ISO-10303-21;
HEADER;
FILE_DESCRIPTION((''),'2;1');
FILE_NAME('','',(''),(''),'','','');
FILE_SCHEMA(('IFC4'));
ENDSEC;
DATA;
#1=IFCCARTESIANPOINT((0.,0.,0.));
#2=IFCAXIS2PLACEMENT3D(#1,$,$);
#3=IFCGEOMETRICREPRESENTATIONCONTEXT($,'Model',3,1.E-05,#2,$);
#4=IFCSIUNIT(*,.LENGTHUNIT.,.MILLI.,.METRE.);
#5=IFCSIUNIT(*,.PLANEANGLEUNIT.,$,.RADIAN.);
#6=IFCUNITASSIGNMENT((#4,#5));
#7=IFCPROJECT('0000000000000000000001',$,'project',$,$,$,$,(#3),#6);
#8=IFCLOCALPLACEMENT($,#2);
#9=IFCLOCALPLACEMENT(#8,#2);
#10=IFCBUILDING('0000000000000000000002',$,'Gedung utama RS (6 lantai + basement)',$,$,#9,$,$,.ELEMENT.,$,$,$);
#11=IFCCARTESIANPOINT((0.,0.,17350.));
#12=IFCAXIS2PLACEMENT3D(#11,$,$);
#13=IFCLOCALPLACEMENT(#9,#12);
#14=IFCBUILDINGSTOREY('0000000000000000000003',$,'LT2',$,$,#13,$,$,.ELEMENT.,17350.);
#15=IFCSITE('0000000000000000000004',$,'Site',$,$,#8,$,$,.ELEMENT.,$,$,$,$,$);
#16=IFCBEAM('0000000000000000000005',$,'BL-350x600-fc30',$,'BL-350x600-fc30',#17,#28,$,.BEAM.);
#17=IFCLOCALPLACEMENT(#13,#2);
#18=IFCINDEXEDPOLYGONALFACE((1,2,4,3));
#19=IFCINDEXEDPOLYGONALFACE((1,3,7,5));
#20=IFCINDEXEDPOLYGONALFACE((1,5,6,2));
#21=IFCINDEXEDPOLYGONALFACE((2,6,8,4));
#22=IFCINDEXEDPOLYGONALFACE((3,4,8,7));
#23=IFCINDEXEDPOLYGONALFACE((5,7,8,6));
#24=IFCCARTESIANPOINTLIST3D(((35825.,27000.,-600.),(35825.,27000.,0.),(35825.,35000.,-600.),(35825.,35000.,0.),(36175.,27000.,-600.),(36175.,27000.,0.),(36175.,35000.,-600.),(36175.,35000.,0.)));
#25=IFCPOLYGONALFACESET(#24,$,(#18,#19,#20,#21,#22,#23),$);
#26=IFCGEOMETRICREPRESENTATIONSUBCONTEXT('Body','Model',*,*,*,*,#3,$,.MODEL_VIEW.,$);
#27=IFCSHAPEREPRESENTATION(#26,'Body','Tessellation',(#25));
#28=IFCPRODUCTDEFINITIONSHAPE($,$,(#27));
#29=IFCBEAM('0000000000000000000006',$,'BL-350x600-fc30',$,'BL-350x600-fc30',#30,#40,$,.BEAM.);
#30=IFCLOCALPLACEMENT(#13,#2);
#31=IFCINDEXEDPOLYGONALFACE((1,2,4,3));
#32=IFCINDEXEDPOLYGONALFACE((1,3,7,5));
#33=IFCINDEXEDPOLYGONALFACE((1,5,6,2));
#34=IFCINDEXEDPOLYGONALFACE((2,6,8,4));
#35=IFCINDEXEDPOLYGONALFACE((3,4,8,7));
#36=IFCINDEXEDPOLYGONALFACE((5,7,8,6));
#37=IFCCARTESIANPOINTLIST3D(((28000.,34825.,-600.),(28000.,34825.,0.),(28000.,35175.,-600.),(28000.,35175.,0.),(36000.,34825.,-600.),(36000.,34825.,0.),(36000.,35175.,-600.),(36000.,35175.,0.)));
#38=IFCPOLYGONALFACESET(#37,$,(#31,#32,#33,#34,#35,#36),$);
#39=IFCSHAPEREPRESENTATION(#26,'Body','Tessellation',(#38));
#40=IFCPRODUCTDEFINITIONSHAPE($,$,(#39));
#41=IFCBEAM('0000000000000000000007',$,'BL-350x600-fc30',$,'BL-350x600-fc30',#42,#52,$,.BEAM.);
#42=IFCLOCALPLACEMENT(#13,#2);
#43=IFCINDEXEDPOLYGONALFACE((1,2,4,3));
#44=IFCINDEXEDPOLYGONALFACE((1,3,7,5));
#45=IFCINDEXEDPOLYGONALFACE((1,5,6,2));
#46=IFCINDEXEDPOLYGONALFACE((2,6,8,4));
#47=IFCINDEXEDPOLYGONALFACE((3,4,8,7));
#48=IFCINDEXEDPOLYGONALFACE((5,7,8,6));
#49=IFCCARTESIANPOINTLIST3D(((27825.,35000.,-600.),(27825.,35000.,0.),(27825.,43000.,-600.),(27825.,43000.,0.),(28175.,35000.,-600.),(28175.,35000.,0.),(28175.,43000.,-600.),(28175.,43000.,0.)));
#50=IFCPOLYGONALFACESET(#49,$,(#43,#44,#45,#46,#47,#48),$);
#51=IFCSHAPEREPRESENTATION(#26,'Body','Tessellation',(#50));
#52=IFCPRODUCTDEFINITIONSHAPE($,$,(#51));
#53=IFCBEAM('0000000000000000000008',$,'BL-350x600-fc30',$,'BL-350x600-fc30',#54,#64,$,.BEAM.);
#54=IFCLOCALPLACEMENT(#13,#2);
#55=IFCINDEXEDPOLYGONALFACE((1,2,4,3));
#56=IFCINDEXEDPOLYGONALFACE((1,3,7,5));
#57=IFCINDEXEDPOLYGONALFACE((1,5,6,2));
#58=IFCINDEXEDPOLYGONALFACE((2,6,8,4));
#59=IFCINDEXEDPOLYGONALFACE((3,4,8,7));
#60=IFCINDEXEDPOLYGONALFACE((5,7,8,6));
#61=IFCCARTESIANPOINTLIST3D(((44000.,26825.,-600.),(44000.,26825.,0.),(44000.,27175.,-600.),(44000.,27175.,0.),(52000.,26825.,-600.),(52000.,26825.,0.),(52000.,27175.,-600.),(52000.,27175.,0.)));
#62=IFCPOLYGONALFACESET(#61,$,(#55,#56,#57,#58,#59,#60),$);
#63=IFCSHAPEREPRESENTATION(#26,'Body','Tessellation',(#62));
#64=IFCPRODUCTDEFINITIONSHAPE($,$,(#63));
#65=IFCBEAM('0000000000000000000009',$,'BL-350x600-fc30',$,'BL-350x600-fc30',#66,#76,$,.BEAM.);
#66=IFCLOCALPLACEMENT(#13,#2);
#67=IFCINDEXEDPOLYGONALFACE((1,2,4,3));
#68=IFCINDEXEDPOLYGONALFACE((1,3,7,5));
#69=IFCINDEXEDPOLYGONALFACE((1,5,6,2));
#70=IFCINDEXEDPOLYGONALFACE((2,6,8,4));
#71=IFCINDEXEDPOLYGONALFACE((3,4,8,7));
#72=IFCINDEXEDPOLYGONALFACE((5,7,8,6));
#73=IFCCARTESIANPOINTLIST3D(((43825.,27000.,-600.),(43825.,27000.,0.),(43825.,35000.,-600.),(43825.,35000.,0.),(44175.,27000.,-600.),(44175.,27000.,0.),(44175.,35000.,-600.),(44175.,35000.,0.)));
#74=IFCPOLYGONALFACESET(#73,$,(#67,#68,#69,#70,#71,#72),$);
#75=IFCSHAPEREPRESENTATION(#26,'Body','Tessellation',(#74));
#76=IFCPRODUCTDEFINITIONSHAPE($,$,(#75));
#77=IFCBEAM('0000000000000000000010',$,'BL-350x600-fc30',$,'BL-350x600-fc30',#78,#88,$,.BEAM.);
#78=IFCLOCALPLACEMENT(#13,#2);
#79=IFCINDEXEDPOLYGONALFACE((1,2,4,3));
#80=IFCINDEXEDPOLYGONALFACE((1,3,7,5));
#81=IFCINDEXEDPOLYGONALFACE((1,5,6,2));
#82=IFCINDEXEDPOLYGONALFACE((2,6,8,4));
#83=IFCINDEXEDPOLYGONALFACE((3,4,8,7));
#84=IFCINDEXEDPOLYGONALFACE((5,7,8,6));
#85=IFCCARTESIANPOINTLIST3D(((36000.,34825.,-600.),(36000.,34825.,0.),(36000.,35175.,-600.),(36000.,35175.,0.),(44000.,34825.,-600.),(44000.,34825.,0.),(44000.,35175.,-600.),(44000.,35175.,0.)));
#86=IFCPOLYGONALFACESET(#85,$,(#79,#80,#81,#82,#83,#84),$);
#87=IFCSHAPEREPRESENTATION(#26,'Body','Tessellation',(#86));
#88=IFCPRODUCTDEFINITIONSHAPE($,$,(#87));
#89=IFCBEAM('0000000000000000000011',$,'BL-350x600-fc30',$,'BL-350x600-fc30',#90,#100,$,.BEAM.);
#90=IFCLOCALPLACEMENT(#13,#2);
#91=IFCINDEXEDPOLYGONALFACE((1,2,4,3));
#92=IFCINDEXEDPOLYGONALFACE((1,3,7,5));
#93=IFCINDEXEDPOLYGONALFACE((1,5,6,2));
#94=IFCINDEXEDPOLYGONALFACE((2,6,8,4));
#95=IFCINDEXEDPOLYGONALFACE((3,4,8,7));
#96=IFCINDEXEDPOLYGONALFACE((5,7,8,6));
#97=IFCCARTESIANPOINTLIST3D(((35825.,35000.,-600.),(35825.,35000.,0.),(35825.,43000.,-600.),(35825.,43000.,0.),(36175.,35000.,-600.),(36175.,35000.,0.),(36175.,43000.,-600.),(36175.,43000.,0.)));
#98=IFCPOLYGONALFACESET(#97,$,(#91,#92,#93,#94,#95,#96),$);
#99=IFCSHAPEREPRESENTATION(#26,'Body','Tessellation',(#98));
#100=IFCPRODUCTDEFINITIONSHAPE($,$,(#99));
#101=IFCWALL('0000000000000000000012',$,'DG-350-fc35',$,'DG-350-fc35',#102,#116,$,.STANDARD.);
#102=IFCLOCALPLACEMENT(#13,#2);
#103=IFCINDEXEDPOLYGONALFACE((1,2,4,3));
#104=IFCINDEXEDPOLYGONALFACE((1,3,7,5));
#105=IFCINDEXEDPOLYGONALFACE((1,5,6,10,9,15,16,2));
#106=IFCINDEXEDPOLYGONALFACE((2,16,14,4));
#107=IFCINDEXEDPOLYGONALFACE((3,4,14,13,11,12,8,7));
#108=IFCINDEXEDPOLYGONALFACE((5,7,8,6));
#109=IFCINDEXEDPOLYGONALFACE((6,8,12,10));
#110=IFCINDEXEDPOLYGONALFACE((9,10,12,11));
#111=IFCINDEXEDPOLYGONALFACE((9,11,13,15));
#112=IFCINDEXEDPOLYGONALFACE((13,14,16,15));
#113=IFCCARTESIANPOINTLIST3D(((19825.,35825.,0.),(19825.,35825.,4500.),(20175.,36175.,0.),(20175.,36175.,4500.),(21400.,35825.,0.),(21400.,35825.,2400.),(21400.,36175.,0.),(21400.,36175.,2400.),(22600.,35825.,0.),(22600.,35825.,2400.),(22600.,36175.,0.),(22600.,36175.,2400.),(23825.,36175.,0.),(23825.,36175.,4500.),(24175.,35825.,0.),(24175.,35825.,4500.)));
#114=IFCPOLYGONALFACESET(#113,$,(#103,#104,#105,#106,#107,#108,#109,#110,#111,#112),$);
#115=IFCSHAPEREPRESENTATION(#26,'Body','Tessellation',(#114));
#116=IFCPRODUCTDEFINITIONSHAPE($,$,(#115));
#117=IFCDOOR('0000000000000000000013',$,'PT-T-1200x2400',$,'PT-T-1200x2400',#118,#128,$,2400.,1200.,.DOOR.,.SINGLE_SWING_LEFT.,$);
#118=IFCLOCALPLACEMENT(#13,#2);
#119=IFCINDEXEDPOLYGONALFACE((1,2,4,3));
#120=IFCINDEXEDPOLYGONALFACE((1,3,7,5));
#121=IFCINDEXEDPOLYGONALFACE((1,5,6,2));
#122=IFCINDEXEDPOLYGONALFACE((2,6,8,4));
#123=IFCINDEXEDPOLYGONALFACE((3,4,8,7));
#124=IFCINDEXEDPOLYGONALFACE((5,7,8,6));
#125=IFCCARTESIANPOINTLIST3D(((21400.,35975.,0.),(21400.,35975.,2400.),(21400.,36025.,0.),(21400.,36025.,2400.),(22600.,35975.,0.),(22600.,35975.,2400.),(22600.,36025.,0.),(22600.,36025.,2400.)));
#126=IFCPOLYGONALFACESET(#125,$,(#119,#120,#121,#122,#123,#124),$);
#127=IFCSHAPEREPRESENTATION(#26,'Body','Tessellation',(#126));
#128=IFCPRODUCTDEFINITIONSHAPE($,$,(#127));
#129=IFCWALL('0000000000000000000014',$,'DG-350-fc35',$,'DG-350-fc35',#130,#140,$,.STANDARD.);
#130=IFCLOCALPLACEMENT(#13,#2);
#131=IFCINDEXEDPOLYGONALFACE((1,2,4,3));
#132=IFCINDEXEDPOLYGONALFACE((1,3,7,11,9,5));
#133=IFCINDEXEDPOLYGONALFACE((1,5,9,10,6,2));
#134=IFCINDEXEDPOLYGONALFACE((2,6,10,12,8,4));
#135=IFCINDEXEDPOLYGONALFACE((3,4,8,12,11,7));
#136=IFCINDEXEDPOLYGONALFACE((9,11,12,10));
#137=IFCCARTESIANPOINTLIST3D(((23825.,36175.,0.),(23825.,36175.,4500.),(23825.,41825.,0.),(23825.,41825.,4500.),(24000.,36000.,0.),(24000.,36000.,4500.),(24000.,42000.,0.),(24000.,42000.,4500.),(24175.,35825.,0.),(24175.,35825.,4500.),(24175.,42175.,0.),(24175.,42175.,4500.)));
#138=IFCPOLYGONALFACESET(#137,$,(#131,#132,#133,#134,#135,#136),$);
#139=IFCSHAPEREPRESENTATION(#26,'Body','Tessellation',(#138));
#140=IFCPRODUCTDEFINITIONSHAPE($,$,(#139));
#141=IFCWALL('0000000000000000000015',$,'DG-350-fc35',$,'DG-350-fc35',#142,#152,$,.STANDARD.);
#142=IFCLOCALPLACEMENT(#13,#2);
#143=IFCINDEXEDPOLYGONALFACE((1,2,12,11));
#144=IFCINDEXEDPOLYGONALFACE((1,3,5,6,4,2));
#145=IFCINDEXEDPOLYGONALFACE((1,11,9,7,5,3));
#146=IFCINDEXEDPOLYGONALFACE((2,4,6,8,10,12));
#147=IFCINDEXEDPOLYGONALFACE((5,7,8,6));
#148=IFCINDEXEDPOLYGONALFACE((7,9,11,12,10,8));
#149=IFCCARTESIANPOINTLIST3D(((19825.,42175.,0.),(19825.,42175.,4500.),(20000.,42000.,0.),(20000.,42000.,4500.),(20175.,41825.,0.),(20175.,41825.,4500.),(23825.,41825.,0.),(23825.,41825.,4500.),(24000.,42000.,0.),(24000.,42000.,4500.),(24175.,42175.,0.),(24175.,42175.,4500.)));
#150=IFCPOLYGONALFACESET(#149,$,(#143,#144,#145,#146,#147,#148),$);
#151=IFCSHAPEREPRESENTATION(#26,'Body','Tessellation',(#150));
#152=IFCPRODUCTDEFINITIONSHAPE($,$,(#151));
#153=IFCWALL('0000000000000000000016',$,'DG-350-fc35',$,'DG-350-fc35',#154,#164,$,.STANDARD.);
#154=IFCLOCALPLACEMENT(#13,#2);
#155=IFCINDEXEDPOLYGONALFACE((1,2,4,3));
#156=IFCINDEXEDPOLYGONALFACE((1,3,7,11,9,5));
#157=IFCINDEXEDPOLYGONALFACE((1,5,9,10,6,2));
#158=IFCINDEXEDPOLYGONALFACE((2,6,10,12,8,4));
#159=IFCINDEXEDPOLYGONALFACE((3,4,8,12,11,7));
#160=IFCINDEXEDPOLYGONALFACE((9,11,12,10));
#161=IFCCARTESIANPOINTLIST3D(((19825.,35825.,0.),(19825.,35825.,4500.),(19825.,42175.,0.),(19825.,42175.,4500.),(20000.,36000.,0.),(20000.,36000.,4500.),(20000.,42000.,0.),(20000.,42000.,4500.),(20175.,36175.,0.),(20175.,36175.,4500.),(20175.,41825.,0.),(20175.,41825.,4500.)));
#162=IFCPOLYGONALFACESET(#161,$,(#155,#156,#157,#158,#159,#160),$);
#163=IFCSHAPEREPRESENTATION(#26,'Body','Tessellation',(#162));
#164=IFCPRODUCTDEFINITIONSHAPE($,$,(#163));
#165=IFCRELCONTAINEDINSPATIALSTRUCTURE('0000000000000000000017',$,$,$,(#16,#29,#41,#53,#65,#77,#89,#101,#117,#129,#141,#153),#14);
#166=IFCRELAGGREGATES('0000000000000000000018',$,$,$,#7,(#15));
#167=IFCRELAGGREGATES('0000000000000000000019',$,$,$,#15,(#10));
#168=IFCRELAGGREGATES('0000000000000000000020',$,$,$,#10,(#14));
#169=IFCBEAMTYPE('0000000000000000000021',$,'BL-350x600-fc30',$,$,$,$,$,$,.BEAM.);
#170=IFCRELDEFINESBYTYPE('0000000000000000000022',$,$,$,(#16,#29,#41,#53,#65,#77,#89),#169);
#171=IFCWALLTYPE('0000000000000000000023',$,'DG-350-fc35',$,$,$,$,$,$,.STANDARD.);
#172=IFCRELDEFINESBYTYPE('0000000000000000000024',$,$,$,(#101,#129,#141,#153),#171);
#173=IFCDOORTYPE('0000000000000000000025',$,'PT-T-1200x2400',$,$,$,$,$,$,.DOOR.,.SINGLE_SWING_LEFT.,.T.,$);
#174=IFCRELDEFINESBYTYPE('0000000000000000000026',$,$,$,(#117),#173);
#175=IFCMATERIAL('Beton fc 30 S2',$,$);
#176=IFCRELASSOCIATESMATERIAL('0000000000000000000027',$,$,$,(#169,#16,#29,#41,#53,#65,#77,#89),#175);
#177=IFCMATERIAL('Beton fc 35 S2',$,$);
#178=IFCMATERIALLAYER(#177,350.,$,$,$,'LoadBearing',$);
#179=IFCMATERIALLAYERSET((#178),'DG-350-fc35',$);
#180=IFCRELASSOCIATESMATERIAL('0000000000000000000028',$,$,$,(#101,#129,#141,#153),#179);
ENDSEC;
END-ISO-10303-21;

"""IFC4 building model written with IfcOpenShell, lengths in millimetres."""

from ifc_helpers import new_model, si_unit, frame, frame_2d, origin, origin_2d, place, context, subcontext, project, spatial, polyline, rectangle, outline, extrude, material, layer, layer_set, layer_usage, material_profile, profile_set, profile_usage, type_object, element, fill, save


model = new_model("IFC4")

# Units and contexts
model_context = context("Model", 3, precision=1e-05, world=origin())
body_context = subcontext(model_context, "Body", "Model", "MODEL_VIEW")
ifc_project = project(units=[si_unit("LENGTHUNIT", "METRE", prefix="MILLI"), si_unit("PLANEANGLEUNIT", "RADIAN")], contexts=[model_context])

# Site, building, storey
site_placement = place(None, origin())
site = spatial("IfcSite", under=ifc_project, at=site_placement, Name="Site", CompositionType="ELEMENT")
building_placement = place(site_placement, origin())
building = spatial("IfcBuilding", under=site, at=building_placement, Name="Gedung utama RS (6 lantai + basement)", CompositionType="ELEMENT")
storey_placement = place(building_placement, frame((0.0, 0.0, 17350.0)))
storey = spatial("IfcBuildingStorey", under=building, at=storey_placement, Name="LT2", CompositionType="ELEMENT", Elevation=17350.0)

# Beams
ifc_material_1 = material(Name="Beton fc 30 S2")
ifc_material_profile_1 = material_profile(ifc_material_1, rectangle(XDim=350.0, YDim=600.0, at=origin_2d()), Name="BL-350x600-fc30")
ifc_profile_set_1 = profile_set([ifc_material_profile_1], Name="BL-350x600-fc30")
ifc_profile_usage_1 = profile_usage(ifc_profile_set_1, cardinal=8)
beam_type = type_object("IfcBeamType", Name="BL-350x600-fc30", PredefinedType="BEAM", material=ifc_profile_set_1)
beam_1_placement = place(storey_placement, frame((36000.0, 27000.0, -300.0)))
element("IfcBeam", 1, at=beam_1_placement, inside=storey, type_object=beam_type, material=ifc_profile_usage_1, Name="BL-350x600-fc30", ObjectType="BL-350x600-fc30", PredefinedType="BEAM", context=body_context, shape_type="SweptSolid", body=[
    extrude(rectangle(XDim=350.0, YDim=600.0, at=origin_2d()), frame((0.0, 0.0, 0.0), z_axis=(0.0, 1.0, 0.0), x_axis=(-1.0, 0.0, 0.0)), (0.0, 0.0, 1.0), 8000.0),
])
beam_2_placement = place(storey_placement, frame((28000.0, 35000.0, -300.0)))
element("IfcBeam", 2, at=beam_2_placement, inside=storey, type_object=beam_type, material=ifc_profile_usage_1, Name="BL-350x600-fc30", ObjectType="BL-350x600-fc30", PredefinedType="BEAM", context=body_context, shape_type="SweptSolid", body=[
    extrude(rectangle(XDim=350.0, YDim=600.0, at=origin_2d()), frame((0.0, 0.0, 0.0), z_axis=(1.0, 0.0, 0.0), x_axis=(0.0, 1.0, 0.0)), (0.0, 0.0, 1.0), 8000.0),
])
beam_3_placement = place(storey_placement, frame((28000.0, 35000.0, -300.0)))
element("IfcBeam", 3, at=beam_3_placement, inside=storey, type_object=beam_type, material=ifc_profile_usage_1, Name="BL-350x600-fc30", ObjectType="BL-350x600-fc30", PredefinedType="BEAM", context=body_context, shape_type="SweptSolid", body=[
    extrude(rectangle(XDim=350.0, YDim=600.0, at=origin_2d()), frame((0.0, 0.0, 0.0), z_axis=(0.0, 1.0, 0.0), x_axis=(-1.0, 0.0, 0.0)), (0.0, 0.0, 1.0), 8000.0),
])
beam_4_placement = place(storey_placement, frame((44000.0, 27000.0, -300.0)))
element("IfcBeam", 4, at=beam_4_placement, inside=storey, type_object=beam_type, material=ifc_profile_usage_1, Name="BL-350x600-fc30", ObjectType="BL-350x600-fc30", PredefinedType="BEAM", context=body_context, shape_type="SweptSolid", body=[
    extrude(rectangle(XDim=350.0, YDim=600.0, at=origin_2d()), frame((0.0, 0.0, 0.0), z_axis=(1.0, 0.0, 0.0), x_axis=(0.0, 1.0, 0.0)), (0.0, 0.0, 1.0), 8000.0),
])
beam_5_placement = place(storey_placement, frame((44000.0, 27000.0, -300.0)))
element("IfcBeam", 5, at=beam_5_placement, inside=storey, type_object=beam_type, material=ifc_profile_usage_1, Name="BL-350x600-fc30", ObjectType="BL-350x600-fc30", PredefinedType="BEAM", context=body_context, shape_type="SweptSolid", body=[
    extrude(rectangle(XDim=350.0, YDim=600.0, at=origin_2d()), frame((0.0, 0.0, 0.0), z_axis=(0.0, 1.0, 0.0), x_axis=(-1.0, 0.0, 0.0)), (0.0, 0.0, 1.0), 8000.0),
])
beam_6_placement = place(storey_placement, frame((36000.0, 35000.0, -300.0)))
element("IfcBeam", 6, at=beam_6_placement, inside=storey, type_object=beam_type, material=ifc_profile_usage_1, Name="BL-350x600-fc30", ObjectType="BL-350x600-fc30", PredefinedType="BEAM", context=body_context, shape_type="SweptSolid", body=[
    extrude(rectangle(XDim=350.0, YDim=600.0, at=origin_2d()), frame((0.0, 0.0, 0.0), z_axis=(1.0, 0.0, 0.0), x_axis=(0.0, 1.0, 0.0)), (0.0, 0.0, 1.0), 8000.0),
])
beam_7_placement = place(storey_placement, frame((36000.0, 35000.0, -300.0)))
element("IfcBeam", 7, at=beam_7_placement, inside=storey, type_object=beam_type, material=ifc_profile_usage_1, Name="BL-350x600-fc30", ObjectType="BL-350x600-fc30", PredefinedType="BEAM", context=body_context, shape_type="SweptSolid", body=[
    extrude(rectangle(XDim=350.0, YDim=600.0, at=origin_2d()), frame((0.0, 0.0, 0.0), z_axis=(0.0, 1.0, 0.0), x_axis=(-1.0, 0.0, 0.0)), (0.0, 0.0, 1.0), 8000.0),
])

# Wall, opening, door
ifc_material_2 = material(Name="Beton fc 35 S2")
ifc_layer = layer(ifc_material_2, 350.0, Category="LoadBearing")
ifc_layer_set = layer_set([ifc_layer], Name="DG-350-fc35")
ifc_layer_usage = layer_usage(ifc_layer_set, "AXIS2", "NEGATIVE", 175.0)
wall_type = type_object("IfcWallType", Name="DG-350-fc35", PredefinedType="STANDARD")
wall_1_placement = place(storey_placement, frame((20000.0, 36000.0, 0.0), z_axis=(0.0, 0.0, 1.0), x_axis=(1.0, 0.0, 0.0)))
wall_1 = element("IfcWall", 8, at=wall_1_placement, inside=storey, type_object=wall_type, material=ifc_layer_usage, Name="DG-350-fc35", ObjectType="DG-350-fc35", PredefinedType="STANDARD", context=body_context, shape_type="SweptSolid", body=[
    extrude(outline(polyline([(-175.0, -175.0), (0.0, 0.0), (175.0, 175.0), (3825.0, 175.0), (4000.0, 0.0), (4175.0, -175.0), (-175.0, -175.0)])), origin(), (0.0, 0.0, 1.0), 4500.0),
])
opening_placement = place(wall_1_placement, frame((1400.0, 0.0, 0.0), z_axis=(0.0, 0.0, 1.0), x_axis=(1.0, 0.0, 0.0)))
opening = element("IfcOpeningElement", 9, at=opening_placement, cuts=wall_1, PredefinedType="OPENING", context=body_context, shape_type="SweptSolid", body=[
    extrude(rectangle(XDim=1200.0, YDim=370.0, at=frame_2d((600.0, 0.0))), origin(), (0.0, 0.0, 1.0), 2400.0),
])
door_type = type_object("IfcDoorType", Name="PT-T-1200x2400", OperationType="SINGLE_SWING_LEFT", ParameterTakesPrecedence=True, PredefinedType="DOOR")
door_placement = place(opening_placement, origin())
door = element("IfcDoor", 10, at=door_placement, inside=storey, type_object=door_type, Name="PT-T-1200x2400", ObjectType="PT-T-1200x2400", OperationType="SINGLE_SWING_LEFT", OverallHeight=2400.0, OverallWidth=1200.0, PredefinedType="DOOR", context=body_context, shape_type="SweptSolid", body=[
    extrude(rectangle(XDim=1200.0, YDim=50.0, at=frame_2d((600.0, 0.0))), origin(), (0.0, 0.0, 1.0), 2400.0),
])
fill(opening, door)

# Walls
wall_2_placement = place(storey_placement, frame((24000.0, 36000.0, 0.0), z_axis=(0.0, 0.0, 1.0), x_axis=(0.0, 1.0, 0.0)))
element("IfcWall", 11, at=wall_2_placement, inside=storey, type_object=wall_type, material=ifc_layer_usage, Name="DG-350-fc35", ObjectType="DG-350-fc35", PredefinedType="STANDARD", context=body_context, shape_type="SweptSolid", body=[
    extrude(outline(polyline([(-175.0, -175.0), (0.0, 0.0), (175.0, 175.0), (5825.0, 175.0), (6000.0, 0.0), (6175.0, -175.0), (-175.0, -175.0)])), origin(), (0.0, 0.0, 1.0), 4500.0),
])
wall_3_placement = place(storey_placement, frame((24000.0, 42000.0, 0.0), z_axis=(0.0, 0.0, 1.0), x_axis=(-1.0, 0.0, 0.0)))
element("IfcWall", 12, at=wall_3_placement, inside=storey, type_object=wall_type, material=ifc_layer_usage, Name="DG-350-fc35", ObjectType="DG-350-fc35", PredefinedType="STANDARD", context=body_context, shape_type="SweptSolid", body=[
    extrude(outline(polyline([(-175.0, -175.0), (0.0, 0.0), (175.0, 175.0), (3825.0, 175.0), (4000.0, 0.0), (4175.0, -175.0), (-175.0, -175.0)])), origin(), (0.0, 0.0, 1.0), 4500.0),
])
wall_4_placement = place(storey_placement, frame((20000.0, 42000.0, 0.0), z_axis=(0.0, 0.0, 1.0), x_axis=(0.0, -1.0, 0.0)))
element("IfcWall", 13, at=wall_4_placement, inside=storey, type_object=wall_type, material=ifc_layer_usage, Name="DG-350-fc35", ObjectType="DG-350-fc35", PredefinedType="STANDARD", context=body_context, shape_type="SweptSolid", body=[
    extrude(outline(polyline([(-175.0, -175.0), (0.0, 0.0), (175.0, 175.0), (5825.0, 175.0), (6000.0, 0.0), (6175.0, -175.0), (-175.0, -175.0)])), origin(), (0.0, 0.0, 1.0), 4500.0),
])

save(model, "model.ifc")
